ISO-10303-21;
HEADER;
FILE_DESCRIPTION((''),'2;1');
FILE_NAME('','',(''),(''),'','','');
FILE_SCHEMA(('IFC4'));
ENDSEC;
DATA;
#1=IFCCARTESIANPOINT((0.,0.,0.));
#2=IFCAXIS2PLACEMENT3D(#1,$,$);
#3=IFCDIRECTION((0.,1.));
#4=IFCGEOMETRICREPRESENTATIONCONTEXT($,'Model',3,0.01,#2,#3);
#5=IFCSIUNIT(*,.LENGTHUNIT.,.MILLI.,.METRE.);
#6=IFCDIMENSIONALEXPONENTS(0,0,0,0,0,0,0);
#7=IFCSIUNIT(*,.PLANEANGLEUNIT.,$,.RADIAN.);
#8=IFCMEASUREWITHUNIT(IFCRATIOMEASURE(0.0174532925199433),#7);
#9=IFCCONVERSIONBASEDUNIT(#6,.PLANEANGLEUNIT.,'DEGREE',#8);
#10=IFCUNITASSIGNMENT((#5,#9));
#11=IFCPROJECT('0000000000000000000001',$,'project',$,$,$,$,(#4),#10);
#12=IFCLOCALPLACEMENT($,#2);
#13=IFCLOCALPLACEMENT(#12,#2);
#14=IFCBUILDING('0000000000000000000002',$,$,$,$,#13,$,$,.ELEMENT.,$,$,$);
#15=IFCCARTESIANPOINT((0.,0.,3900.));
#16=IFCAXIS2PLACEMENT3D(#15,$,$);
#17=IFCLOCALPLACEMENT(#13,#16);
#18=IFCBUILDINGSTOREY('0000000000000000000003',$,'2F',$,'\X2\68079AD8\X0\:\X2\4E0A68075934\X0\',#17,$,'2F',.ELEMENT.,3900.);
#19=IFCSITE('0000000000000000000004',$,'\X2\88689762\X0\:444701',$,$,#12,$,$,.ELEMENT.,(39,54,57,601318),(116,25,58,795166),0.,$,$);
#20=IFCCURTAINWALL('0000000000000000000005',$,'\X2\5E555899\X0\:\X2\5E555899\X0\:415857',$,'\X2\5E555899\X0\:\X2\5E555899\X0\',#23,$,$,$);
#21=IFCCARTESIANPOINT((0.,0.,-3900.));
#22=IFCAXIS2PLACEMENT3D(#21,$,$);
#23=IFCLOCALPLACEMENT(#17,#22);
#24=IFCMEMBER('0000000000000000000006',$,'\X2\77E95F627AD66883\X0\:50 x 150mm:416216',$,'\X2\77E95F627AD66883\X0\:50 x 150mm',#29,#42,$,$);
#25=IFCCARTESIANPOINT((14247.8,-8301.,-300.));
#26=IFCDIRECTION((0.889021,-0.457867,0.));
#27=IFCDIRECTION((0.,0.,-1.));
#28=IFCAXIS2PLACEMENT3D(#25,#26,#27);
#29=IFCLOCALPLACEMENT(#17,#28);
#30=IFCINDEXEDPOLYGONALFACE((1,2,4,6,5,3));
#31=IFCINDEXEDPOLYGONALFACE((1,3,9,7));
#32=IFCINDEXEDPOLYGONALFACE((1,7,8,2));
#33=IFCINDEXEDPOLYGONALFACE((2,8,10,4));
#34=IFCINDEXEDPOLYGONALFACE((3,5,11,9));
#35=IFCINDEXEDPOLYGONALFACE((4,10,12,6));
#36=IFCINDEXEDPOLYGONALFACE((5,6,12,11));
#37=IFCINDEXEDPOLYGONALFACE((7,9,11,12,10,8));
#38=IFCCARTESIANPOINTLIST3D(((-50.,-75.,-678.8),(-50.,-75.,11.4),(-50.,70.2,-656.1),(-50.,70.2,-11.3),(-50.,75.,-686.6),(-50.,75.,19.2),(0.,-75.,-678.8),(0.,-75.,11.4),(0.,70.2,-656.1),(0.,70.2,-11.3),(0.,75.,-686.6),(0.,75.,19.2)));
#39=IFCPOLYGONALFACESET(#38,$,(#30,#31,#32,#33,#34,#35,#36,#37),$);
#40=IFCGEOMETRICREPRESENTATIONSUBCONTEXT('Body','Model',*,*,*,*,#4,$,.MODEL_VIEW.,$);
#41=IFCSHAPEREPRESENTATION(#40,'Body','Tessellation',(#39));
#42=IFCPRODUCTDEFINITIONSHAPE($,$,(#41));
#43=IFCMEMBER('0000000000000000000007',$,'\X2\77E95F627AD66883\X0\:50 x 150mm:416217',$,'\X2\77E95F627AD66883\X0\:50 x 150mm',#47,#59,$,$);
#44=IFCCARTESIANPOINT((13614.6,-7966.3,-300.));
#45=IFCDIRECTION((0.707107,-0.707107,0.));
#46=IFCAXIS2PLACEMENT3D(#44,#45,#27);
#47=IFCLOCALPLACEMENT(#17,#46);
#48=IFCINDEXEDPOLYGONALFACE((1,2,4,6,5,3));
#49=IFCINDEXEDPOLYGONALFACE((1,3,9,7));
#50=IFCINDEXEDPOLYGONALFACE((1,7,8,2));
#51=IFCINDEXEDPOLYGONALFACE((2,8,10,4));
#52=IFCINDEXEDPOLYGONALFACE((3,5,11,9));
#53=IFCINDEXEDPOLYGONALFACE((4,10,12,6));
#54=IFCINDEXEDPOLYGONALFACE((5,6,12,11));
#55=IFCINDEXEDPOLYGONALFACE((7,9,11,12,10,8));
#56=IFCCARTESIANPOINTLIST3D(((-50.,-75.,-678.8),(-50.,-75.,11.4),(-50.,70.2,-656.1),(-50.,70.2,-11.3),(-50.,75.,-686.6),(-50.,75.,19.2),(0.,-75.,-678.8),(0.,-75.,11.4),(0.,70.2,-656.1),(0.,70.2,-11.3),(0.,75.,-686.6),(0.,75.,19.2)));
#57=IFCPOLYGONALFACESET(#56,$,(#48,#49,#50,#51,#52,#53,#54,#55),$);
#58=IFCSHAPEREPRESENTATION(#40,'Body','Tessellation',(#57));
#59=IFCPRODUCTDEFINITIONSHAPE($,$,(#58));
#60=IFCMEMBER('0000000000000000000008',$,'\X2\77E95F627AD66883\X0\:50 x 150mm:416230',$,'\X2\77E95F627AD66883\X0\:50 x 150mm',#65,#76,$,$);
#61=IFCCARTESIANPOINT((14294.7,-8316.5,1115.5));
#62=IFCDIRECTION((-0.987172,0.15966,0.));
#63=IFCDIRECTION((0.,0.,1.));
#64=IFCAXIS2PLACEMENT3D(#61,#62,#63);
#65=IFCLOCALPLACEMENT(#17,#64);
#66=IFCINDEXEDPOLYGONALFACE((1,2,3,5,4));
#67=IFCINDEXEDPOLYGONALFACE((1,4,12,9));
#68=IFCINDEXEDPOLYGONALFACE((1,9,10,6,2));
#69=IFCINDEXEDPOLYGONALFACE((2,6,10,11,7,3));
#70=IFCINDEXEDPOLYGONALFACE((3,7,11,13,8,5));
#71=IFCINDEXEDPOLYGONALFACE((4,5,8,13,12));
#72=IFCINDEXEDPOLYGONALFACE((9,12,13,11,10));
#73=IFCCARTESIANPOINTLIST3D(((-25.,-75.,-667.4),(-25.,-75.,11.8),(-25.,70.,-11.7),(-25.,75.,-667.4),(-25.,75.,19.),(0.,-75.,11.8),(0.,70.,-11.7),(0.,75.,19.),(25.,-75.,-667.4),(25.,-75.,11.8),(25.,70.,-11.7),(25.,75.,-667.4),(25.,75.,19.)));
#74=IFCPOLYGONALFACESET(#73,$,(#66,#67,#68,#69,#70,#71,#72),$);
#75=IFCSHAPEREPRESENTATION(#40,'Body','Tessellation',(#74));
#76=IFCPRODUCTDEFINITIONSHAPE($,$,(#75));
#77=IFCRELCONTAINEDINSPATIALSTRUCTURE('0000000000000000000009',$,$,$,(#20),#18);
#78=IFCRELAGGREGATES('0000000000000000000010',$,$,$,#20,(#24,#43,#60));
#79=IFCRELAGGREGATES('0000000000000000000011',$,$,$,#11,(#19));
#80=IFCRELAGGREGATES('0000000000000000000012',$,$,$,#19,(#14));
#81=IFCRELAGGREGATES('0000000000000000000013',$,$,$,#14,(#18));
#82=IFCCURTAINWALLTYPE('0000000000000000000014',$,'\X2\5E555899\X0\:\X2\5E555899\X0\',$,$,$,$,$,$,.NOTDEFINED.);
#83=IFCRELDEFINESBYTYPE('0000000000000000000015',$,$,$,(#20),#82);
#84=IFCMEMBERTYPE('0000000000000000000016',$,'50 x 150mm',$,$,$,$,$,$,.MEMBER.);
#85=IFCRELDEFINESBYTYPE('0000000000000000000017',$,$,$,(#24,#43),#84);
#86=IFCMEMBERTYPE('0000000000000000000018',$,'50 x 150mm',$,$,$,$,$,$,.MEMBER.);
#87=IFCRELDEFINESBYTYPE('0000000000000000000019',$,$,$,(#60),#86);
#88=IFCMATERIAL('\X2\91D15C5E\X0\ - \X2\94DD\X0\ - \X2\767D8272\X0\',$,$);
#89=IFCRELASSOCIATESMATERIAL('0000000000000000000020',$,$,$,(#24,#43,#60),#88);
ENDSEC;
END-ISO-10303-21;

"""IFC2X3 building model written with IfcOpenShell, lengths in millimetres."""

from ifc_helpers import new_model, entity, si_unit, converted_unit, direction, frame, origin, origin_2d_with_axis, place, context, subcontext, project, spatial, polyline, rectangle, extrude, clip, bounded_halfspace, source, transform, mapped, material, type_object, type_shapes, element, aggregate, save


model = new_model("IFC2X3")

# Units and contexts
model_context = context("Model", 3, precision=0.01, world=origin(), true_north=direction((0.0, 1.0)))
body_context = subcontext(model_context, "Body", "Model", "MODEL_VIEW")
ifc_project = project(units=[si_unit("LENGTHUNIT", "METRE", prefix="MILLI"), converted_unit("PLANEANGLEUNIT", "DEGREE", entity("IfcRatioMeasure", 0.0174532925199433), si_unit("PLANEANGLEUNIT", "RADIAN"), dimensions=[0, 0, 0, 0, 0, 0, 0])], contexts=[model_context])

# Site, building, storey
site_placement = place(None, origin())
site = spatial("IfcSite", under=ifc_project, at=site_placement, Name="表面:444701", CompositionType="ELEMENT", RefLatitude=(39, 54, 57, 601318), RefLongitude=(116, 25, 58, 795166), RefElevation=0.0)
building_placement = place(site_placement, origin())
building = spatial("IfcBuilding", under=site, at=building_placement, CompositionType="ELEMENT")
storey_placement = place(building_placement, frame((0.0, 0.0, 3900.0)))
storey = spatial("IfcBuildingStorey", under=building, at=storey_placement, Name="2F", ObjectType="标高:上标头", LongName="2F", CompositionType="ELEMENT", Elevation=3900.0)

# Shared definitions
curtain_wall_type = type_object("IfcCurtainWallType", Name="幕墙:幕墙", PredefinedType="NOTDEFINED")
ifc_material_1 = material(Name="金属 - 铝 - 白色")

# Curtain wall
curtain_wall_1_placement = place(storey_placement, frame((0.0, 0.0, -3900.0)))
curtain_wall_1 = element("IfcCurtainWall", 1, at=curtain_wall_1_placement, inside=storey, type_object=curtain_wall_type, Name="幕墙:幕墙:415857", ObjectType="幕墙:幕墙")

# Members
member_type_1 = type_object("IfcMemberType", Name="50 x 150mm", PredefinedType="MEMBER")
shared_shape_1 = source(origin(), body_context, "Body", "Clipping", [
    clip(clip(clip(clip(extrude(rectangle(XDim=50.0, YDim=150.0, at=origin_2d_with_axis()), frame((-25.0, 0.0, -686.6)), (0.0, 0.0, 1.0), 705.8), bounded_halfspace(frame((0.0, 70.2, -656.1), z_axis=(0.0, 0.154283, -0.988027), x_axis=(-1.0, 0.0, 0.0)), False, frame((-25.0, 0.0, -686.6)), polyline([(25.0, 70.2), (25.0, -75.0), (-25.0, -75.0), (-25.0, 70.2), (25.0, 70.2)]))), bounded_halfspace(frame((0.0, 78.0, -705.5), z_axis=(0.0, -0.988027, -0.154283), x_axis=(-1.0, 0.0, 0.0)), False, frame((-25.0, 0.0, -686.6)), polyline([(25.0, 75.0), (25.0, 70.2), (-25.0, 70.2), (-25.0, 75.0), (25.0, 75.0)]))), bounded_halfspace(frame((0.0, 70.2, -11.3), z_axis=(0.0, -0.988027, 0.154283), x_axis=(-1.0, 0.0, 0.0)), False, frame((-25.0, 0.0, -686.6)), polyline([(25.0, 75.0), (-25.0, 75.0), (-25.0, 70.2), (25.0, 70.2), (25.0, 75.0)]))), bounded_halfspace(frame((0.0, -78.0, 11.9), z_axis=(0.0, 0.154283, 0.988027), x_axis=(-1.0, 0.0, 0.0)), False, frame((-25.0, 0.0, -686.6)), polyline([(-25.0, 70.2), (-25.0, -75.0), (25.0, -75.0), (25.0, 70.2), (-25.0, 70.2)]))),
])
type_shapes(member_type_1, [shared_shape_1])
member_1_placement = place(storey_placement, frame((14247.8, -8301.0, -300.0), z_axis=(0.889021, -0.457867, 0.0), x_axis=(0.0, 0.0, -1.0)))
member_1 = element("IfcMember", 2, at=member_1_placement, type_object=member_type_1, material=ifc_material_1, Name="矩形竖梃:50 x 150mm:416216", ObjectType="矩形竖梃:50 x 150mm", context=body_context, shape_type="MappedRepresentation", body=[
    mapped(shared_shape_1, transform((0.0, 0.0, 0.0), scale=1.0)),
])
member_2_placement = place(storey_placement, frame((13614.6, -7966.3, -300.0), z_axis=(0.707107, -0.707107, 0.0), x_axis=(0.0, 0.0, -1.0)))
member_2 = element("IfcMember", 3, at=member_2_placement, type_object=member_type_1, material=ifc_material_1, Name="矩形竖梃:50 x 150mm:416217", ObjectType="矩形竖梃:50 x 150mm", context=body_context, shape_type="MappedRepresentation", body=[
    mapped(shared_shape_1, transform((0.0, 0.0, 0.0), scale=1.0)),
])
member_type_2 = type_object("IfcMemberType", Name="50 x 150mm", PredefinedType="MEMBER")
shared_shape_2 = source(origin(), body_context, "Body", "Clipping", [
    clip(clip(clip(clip(extrude(rectangle(XDim=150.0, YDim=50.0, at=origin_2d_with_axis()), frame((0.0, 0.0, -667.4), z_axis=(0.0, 0.0, 1.0), x_axis=(0.0, -1.0, 0.0)), (0.0, 0.0, 1.0), 686.4), bounded_halfspace(frame((-1415.5, 78.0, 37.7), z_axis=(0.0, -0.987172, 0.15966), x_axis=(1.0, 0.0, 0.0)), False, frame((0.0, 0.0, -667.4), z_axis=(0.0, 0.0, 1.0), x_axis=(0.0, -1.0, 0.0)), polyline([(-75.0, 0.0), (-75.0, -25.0), (-70.0, -25.0), (-70.0, 0.0), (-75.0, 0.0)]))), bounded_halfspace(frame((0.0, 78.0, 37.7), z_axis=(0.0, -0.987172, 0.15966), x_axis=(1.0, 0.0, 0.0)), False, frame((0.0, 0.0, -667.4), z_axis=(0.0, 0.0, 1.0), x_axis=(0.0, -1.0, 0.0)), polyline([(-75.0, 25.0), (-75.0, 0.0), (-70.0, 0.0), (-70.0, 25.0), (-75.0, 25.0)]))), bounded_halfspace(frame((-1415.5, 70.0, -11.7), z_axis=(0.0, 0.15966, 0.987172), x_axis=(1.0, 0.0, 0.0)), False, frame((0.0, 0.0, -667.4), z_axis=(0.0, 0.0, 1.0), x_axis=(0.0, -1.0, 0.0)), polyline([(-70.0, -25.0), (75.0, -25.0), (75.0, 0.0), (-70.0, 0.0), (-70.0, -25.0)]))), bounded_halfspace(frame((0.0, 70.0, -11.7), z_axis=(0.0, 0.15966, 0.987172), x_axis=(1.0, 0.0, 0.0)), False, frame((0.0, 0.0, -667.4), z_axis=(0.0, 0.0, 1.0), x_axis=(0.0, -1.0, 0.0)), polyline([(75.0, 0.0), (75.0, 25.0), (-70.0, 25.0), (-70.0, 0.0), (75.0, 0.0)]))),
])
type_shapes(member_type_2, [shared_shape_2])
member_3_placement = place(storey_placement, frame((14294.7, -8316.5, 1115.5), z_axis=(-0.987172, 0.15966, 0.0), x_axis=(0.0, 0.0, 1.0)))
member_3 = element("IfcMember", 4, at=member_3_placement, type_object=member_type_2, material=ifc_material_1, Name="矩形竖梃:50 x 150mm:416230", ObjectType="矩形竖梃:50 x 150mm", context=body_context, shape_type="MappedRepresentation", body=[
    mapped(shared_shape_2, transform((0.0, 0.0, 0.0), scale=1.0)),
])

aggregate(curtain_wall_1, [member_1, member_2, member_3])

save(model, "model.ifc")
